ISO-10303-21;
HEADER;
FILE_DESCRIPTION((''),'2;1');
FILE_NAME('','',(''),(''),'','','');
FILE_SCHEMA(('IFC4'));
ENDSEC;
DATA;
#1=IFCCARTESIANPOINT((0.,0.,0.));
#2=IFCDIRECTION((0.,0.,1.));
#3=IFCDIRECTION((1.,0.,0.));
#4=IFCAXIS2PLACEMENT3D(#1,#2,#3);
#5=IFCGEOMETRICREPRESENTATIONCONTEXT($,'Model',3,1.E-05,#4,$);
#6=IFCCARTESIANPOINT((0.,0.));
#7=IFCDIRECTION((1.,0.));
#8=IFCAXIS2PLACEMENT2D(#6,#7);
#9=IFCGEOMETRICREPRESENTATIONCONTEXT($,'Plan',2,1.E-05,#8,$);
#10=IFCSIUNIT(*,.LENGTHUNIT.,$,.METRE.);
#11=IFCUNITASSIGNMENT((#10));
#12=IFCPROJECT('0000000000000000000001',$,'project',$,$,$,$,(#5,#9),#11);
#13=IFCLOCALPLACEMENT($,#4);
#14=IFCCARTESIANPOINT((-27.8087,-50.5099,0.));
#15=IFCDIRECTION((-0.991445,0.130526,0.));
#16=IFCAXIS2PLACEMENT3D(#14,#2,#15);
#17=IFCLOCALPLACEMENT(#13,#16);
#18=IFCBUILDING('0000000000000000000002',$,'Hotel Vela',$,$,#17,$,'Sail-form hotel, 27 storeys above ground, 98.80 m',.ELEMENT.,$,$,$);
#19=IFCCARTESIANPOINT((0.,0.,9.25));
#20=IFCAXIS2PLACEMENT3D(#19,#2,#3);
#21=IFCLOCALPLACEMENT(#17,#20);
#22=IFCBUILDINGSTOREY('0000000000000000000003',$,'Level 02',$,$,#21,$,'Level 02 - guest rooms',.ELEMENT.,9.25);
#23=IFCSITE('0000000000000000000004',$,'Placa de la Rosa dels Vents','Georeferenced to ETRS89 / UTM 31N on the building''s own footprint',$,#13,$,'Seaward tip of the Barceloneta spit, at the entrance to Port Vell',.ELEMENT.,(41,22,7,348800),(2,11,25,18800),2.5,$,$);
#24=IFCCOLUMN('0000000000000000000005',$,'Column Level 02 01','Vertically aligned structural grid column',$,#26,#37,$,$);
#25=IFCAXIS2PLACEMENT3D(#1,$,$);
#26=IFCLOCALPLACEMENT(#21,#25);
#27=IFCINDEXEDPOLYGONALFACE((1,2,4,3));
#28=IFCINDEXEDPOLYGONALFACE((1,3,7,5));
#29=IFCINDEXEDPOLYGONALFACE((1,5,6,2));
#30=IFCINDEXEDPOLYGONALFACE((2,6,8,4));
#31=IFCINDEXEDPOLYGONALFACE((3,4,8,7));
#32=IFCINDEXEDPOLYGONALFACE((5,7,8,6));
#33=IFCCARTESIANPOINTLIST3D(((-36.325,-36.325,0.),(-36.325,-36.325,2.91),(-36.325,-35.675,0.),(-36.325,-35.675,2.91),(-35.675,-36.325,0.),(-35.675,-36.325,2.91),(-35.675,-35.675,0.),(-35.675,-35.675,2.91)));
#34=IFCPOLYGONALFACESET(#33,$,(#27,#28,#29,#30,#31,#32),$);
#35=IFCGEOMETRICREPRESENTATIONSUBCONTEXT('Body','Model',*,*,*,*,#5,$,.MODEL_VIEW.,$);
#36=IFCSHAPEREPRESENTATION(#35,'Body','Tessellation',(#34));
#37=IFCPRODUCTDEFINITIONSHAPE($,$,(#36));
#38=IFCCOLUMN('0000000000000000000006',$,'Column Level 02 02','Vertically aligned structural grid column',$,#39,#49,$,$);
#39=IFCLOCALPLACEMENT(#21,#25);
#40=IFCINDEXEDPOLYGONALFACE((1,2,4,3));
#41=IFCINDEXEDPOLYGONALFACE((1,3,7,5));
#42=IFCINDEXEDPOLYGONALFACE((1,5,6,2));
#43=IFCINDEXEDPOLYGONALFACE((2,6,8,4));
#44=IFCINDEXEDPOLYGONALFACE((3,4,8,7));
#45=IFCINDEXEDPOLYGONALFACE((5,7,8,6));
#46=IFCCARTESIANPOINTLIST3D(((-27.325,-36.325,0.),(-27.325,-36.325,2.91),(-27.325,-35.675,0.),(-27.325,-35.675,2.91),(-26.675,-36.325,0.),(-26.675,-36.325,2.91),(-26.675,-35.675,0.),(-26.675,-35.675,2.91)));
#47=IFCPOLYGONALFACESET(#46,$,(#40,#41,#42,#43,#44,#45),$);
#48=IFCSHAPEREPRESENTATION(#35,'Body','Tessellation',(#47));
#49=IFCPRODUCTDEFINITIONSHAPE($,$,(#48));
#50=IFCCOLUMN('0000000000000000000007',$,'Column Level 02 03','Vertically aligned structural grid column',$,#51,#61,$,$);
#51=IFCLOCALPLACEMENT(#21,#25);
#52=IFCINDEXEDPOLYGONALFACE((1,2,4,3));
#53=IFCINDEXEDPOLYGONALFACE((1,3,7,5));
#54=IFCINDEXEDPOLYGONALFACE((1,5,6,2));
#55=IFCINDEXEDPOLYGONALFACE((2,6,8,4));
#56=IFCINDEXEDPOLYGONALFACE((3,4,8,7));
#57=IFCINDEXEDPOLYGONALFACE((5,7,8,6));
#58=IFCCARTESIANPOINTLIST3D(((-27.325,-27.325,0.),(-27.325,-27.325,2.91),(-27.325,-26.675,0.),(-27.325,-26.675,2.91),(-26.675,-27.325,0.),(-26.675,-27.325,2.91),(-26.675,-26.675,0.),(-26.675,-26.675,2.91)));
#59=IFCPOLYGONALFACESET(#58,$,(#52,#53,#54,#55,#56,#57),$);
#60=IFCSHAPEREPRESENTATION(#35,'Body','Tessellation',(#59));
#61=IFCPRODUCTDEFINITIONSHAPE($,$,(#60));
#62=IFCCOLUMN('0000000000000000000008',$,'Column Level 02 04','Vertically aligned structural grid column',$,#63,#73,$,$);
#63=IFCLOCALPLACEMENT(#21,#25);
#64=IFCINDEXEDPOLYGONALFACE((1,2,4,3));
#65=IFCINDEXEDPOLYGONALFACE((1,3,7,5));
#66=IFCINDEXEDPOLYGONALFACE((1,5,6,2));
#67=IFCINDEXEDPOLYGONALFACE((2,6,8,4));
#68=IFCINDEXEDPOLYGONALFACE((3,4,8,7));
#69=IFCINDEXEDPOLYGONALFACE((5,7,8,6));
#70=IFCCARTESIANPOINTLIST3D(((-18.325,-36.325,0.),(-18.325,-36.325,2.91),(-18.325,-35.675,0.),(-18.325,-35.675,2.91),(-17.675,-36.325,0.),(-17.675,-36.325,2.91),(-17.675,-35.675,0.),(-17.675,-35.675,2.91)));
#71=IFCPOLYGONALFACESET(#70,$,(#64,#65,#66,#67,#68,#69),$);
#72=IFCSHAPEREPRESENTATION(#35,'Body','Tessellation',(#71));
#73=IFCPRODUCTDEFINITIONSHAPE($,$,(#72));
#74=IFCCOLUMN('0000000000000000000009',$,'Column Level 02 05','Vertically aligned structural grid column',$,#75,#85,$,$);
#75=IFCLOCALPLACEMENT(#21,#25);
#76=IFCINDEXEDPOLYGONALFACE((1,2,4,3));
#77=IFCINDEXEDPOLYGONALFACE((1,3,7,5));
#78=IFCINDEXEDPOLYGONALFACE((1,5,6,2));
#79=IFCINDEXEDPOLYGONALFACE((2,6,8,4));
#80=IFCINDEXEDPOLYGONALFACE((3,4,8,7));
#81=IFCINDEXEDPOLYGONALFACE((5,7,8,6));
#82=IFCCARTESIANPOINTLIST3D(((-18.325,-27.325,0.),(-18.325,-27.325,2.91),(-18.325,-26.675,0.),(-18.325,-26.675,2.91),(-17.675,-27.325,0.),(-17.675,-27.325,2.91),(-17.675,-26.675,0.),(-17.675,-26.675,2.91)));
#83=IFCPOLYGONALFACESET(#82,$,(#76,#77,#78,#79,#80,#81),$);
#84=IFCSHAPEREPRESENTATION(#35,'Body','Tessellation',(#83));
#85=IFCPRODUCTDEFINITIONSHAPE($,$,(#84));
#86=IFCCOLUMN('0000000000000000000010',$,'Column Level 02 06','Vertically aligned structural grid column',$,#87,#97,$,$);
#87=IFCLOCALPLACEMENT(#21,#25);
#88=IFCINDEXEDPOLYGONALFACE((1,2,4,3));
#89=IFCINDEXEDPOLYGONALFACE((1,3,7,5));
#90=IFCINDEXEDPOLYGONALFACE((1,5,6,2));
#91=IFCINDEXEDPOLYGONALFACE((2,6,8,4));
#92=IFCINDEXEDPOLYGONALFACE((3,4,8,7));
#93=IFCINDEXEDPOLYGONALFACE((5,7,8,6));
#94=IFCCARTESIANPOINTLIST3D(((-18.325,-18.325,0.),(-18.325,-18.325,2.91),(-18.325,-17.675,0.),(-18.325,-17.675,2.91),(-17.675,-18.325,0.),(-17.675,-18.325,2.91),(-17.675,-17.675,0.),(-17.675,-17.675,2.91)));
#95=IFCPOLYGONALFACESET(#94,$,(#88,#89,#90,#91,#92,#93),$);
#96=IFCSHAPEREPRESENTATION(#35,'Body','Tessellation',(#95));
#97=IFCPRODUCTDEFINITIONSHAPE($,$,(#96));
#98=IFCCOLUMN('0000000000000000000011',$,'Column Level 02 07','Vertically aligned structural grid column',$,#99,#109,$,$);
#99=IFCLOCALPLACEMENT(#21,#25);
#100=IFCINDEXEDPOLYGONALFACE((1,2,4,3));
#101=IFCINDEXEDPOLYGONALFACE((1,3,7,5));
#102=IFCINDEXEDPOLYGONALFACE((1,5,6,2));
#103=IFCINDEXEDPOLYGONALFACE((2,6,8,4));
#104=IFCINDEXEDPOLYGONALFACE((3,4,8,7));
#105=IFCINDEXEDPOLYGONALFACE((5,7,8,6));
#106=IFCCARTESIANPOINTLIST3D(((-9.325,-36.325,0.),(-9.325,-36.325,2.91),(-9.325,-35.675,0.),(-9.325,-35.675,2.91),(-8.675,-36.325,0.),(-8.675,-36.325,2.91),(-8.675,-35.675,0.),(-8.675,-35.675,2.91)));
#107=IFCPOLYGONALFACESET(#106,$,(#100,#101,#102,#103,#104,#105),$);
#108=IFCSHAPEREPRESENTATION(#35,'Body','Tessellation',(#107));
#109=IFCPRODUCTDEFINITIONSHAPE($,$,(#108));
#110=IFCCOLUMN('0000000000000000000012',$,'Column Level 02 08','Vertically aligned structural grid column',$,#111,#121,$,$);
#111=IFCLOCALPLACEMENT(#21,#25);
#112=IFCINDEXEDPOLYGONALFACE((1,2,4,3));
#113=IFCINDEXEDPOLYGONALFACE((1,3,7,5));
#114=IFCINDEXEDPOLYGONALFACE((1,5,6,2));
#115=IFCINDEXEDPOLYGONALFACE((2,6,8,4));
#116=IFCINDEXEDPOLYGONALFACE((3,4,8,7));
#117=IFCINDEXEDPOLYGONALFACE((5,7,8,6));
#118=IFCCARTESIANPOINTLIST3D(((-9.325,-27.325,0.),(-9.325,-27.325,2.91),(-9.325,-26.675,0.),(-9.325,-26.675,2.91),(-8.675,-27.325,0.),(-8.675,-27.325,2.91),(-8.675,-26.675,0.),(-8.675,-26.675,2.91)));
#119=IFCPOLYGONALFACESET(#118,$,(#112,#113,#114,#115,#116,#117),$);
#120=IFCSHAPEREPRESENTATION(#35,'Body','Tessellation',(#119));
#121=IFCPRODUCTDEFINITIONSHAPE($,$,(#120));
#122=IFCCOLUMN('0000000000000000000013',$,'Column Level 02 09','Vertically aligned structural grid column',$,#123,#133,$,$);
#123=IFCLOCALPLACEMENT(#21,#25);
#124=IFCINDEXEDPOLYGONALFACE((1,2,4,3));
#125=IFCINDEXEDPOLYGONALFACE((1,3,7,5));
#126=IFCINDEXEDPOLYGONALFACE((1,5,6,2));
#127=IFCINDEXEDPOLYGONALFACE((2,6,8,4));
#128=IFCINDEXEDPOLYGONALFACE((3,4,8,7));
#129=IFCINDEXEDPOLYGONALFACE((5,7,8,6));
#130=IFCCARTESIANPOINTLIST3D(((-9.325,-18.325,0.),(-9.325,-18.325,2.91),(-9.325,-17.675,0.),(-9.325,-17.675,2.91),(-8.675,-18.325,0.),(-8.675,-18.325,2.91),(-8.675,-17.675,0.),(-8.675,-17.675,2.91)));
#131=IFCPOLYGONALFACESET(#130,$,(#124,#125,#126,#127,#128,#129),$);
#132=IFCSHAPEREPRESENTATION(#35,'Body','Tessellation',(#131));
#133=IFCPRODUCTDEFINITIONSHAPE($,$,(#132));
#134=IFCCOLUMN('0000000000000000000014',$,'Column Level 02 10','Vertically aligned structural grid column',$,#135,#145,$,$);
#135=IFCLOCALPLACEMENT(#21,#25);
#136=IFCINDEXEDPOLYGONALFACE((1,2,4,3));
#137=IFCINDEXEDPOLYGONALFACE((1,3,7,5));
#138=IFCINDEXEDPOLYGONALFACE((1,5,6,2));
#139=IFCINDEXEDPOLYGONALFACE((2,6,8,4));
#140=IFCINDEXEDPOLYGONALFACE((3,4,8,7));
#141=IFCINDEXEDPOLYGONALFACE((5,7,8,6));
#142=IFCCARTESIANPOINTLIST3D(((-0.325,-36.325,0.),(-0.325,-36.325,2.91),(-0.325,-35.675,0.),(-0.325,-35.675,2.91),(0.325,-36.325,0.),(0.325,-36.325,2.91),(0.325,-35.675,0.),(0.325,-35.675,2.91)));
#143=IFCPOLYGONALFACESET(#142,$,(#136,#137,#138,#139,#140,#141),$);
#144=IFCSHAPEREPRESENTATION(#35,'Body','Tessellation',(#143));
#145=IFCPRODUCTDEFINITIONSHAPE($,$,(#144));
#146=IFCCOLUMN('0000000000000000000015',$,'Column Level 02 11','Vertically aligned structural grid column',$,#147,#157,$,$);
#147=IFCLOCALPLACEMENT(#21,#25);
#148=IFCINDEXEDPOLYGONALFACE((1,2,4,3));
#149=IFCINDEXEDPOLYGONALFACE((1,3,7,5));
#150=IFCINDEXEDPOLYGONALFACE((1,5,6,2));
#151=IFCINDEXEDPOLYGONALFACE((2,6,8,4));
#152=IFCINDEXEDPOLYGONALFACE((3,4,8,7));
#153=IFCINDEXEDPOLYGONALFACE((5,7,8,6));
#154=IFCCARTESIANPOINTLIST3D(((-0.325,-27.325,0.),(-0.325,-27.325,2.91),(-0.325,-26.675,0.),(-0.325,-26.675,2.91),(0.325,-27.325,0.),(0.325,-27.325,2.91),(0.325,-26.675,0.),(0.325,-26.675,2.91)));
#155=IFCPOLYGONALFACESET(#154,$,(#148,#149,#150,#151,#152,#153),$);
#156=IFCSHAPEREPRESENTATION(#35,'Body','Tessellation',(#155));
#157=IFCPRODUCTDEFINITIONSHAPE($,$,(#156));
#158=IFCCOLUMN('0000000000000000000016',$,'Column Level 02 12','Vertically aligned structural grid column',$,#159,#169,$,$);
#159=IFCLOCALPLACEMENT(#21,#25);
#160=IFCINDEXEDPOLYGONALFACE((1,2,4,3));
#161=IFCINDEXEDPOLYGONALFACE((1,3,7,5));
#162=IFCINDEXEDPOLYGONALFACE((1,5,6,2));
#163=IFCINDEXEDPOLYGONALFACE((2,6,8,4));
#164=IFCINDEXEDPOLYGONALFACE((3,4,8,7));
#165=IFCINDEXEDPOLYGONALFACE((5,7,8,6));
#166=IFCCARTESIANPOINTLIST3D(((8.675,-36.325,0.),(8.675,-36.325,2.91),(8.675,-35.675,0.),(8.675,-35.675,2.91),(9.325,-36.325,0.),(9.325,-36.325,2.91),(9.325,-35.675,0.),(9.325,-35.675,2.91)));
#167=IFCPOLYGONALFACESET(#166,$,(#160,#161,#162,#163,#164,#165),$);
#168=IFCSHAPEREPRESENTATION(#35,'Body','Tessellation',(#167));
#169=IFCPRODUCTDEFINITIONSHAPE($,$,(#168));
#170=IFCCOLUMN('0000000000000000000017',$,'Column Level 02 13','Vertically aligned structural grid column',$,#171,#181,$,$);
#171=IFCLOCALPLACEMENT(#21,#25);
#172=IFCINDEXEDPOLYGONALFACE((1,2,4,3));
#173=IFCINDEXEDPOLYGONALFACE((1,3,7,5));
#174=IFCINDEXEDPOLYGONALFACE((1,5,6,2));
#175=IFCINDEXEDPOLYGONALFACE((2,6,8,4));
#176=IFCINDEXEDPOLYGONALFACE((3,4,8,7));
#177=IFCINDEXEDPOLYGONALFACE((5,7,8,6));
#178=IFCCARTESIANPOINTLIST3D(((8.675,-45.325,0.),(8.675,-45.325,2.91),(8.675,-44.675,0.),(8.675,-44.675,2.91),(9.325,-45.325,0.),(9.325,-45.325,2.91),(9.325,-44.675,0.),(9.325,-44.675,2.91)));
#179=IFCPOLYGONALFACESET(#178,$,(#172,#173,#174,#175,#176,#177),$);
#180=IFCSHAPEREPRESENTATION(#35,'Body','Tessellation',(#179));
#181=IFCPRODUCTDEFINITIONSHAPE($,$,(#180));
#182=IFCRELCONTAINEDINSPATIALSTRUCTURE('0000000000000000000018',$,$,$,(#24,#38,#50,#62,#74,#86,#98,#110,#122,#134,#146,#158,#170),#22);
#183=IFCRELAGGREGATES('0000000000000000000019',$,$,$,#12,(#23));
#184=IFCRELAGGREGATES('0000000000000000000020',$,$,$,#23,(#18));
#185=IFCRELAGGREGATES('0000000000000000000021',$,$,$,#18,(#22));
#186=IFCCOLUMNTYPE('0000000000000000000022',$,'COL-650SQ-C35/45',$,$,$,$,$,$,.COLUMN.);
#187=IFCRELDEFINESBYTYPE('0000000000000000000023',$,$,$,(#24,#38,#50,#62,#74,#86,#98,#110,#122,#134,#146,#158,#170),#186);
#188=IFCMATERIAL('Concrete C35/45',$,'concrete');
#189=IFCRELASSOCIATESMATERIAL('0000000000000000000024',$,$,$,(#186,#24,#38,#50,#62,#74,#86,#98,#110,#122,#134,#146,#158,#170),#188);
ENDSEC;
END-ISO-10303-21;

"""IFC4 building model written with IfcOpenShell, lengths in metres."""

from ifc_helpers import new_model, si_unit, frame, origin_with_axes, origin_2d_with_axis, place, context, subcontext, project, spatial, line, indexed_curve, rectangle, outline, extrude, material, material_profile, profile_set, profile_usage, type_object, element, save


model = new_model("IFC4")

# Units and contexts
model_context = context("Model", 3, precision=1e-05, world=origin_with_axes())
plan_context = context("Plan", 2, precision=1e-05, world=origin_2d_with_axis())
body_context = subcontext(model_context, "Body", "Model", "MODEL_VIEW")
ifc_project = project(units=[si_unit("LENGTHUNIT", "METRE")], contexts=[model_context, plan_context])

# Site, building, storey
site_placement = place(None, origin_with_axes())
site = spatial("IfcSite", under=ifc_project, at=site_placement, Name="Placa de la Rosa dels Vents", Description="Georeferenced to ETRS89 / UTM 31N on the building's own footprint", LongName="Seaward tip of the Barceloneta spit, at the entrance to Port Vell", CompositionType="ELEMENT", RefLatitude=(41, 22, 7, 348800), RefLongitude=(2, 11, 25, 18800), RefElevation=2.5)
building_placement = place(site_placement, frame((-27.8087, -50.5099, 0.0), z_axis=(0.0, 0.0, 1.0), x_axis=(-0.991445, 0.130526, 0.0)))
building = spatial("IfcBuilding", under=site, at=building_placement, Name="Hotel Vela", LongName="Sail-form hotel, 27 storeys above ground, 98.80 m", CompositionType="ELEMENT")
storey_placement = place(building_placement, frame((0.0, 0.0, 9.25), z_axis=(0.0, 0.0, 1.0), x_axis=(1.0, 0.0, 0.0)))
storey = spatial("IfcBuildingStorey", under=building, at=storey_placement, Name="Level 02", LongName="Level 02 - guest rooms", CompositionType="ELEMENT", Elevation=9.25)

# Columns
ifc_material = material(Name="Concrete C35/45", Category="concrete")
ifc_material_profile = material_profile(ifc_material, rectangle(XDim=0.65, YDim=0.65))
ifc_profile_set = profile_set([ifc_material_profile], Name="COL-650SQ-C35/45")
ifc_profile_usage_1 = profile_usage(ifc_profile_set)
column_type = type_object("IfcColumnType", Name="COL-650SQ-C35/45", PredefinedType="COLUMN", material=ifc_profile_set)
column_1_placement = place(storey_placement, frame((-36.325, -36.325, 0.0), z_axis=(0.0, 0.0, 1.0), x_axis=(1.0, 0.0, 0.0)))
element("IfcColumn", 1, at=column_1_placement, inside=storey, type_object=column_type, material=ifc_profile_usage_1, Name="Column Level 02 01", Description="Vertically aligned structural grid column", context=body_context, shape_type="SweptSolid", body=[
    extrude(outline(indexed_curve([(0.0, 0.0), (0.65, 0.0), (0.65, 0.65), (0.0, 0.65)], segments=[line(1, 2, 3, 4, 1)])), origin_with_axes(), (0.0, 0.0, 1.0), 2.91),
])
ifc_profile_usage_2 = profile_usage(ifc_profile_set)
column_2_placement = place(storey_placement, frame((-27.325, -36.325, 0.0), z_axis=(0.0, 0.0, 1.0), x_axis=(1.0, 0.0, 0.0)))
element("IfcColumn", 2, at=column_2_placement, inside=storey, type_object=column_type, material=ifc_profile_usage_2, Name="Column Level 02 02", Description="Vertically aligned structural grid column", context=body_context, shape_type="SweptSolid", body=[
    extrude(outline(indexed_curve([(0.0, 0.0), (0.65, 0.0), (0.65, 0.65), (0.0, 0.65)], segments=[line(1, 2, 3, 4, 1)])), origin_with_axes(), (0.0, 0.0, 1.0), 2.91),
])
ifc_profile_usage_3 = profile_usage(ifc_profile_set)
column_3_placement = place(storey_placement, frame((-27.325, -27.325, 0.0), z_axis=(0.0, 0.0, 1.0), x_axis=(1.0, 0.0, 0.0)))
element("IfcColumn", 3, at=column_3_placement, inside=storey, type_object=column_type, material=ifc_profile_usage_3, Name="Column Level 02 03", Description="Vertically aligned structural grid column", context=body_context, shape_type="SweptSolid", body=[
    extrude(outline(indexed_curve([(0.0, 0.0), (0.65, 0.0), (0.65, 0.65), (0.0, 0.65)], segments=[line(1, 2, 3, 4, 1)])), origin_with_axes(), (0.0, 0.0, 1.0), 2.91),
])
ifc_profile_usage_4 = profile_usage(ifc_profile_set)
column_4_placement = place(storey_placement, frame((-18.325, -36.325, 0.0), z_axis=(0.0, 0.0, 1.0), x_axis=(1.0, 0.0, 0.0)))
element("IfcColumn", 4, at=column_4_placement, inside=storey, type_object=column_type, material=ifc_profile_usage_4, Name="Column Level 02 04", Description="Vertically aligned structural grid column", context=body_context, shape_type="SweptSolid", body=[
    extrude(outline(indexed_curve([(0.0, 0.0), (0.65, 0.0), (0.65, 0.65), (0.0, 0.65)], segments=[line(1, 2, 3, 4, 1)])), origin_with_axes(), (0.0, 0.0, 1.0), 2.91),
])
ifc_profile_usage_5 = profile_usage(ifc_profile_set)
column_5_placement = place(storey_placement, frame((-18.325, -27.325, 0.0), z_axis=(0.0, 0.0, 1.0), x_axis=(1.0, 0.0, 0.0)))
element("IfcColumn", 5, at=column_5_placement, inside=storey, type_object=column_type, material=ifc_profile_usage_5, Name="Column Level 02 05", Description="Vertically aligned structural grid column", context=body_context, shape_type="SweptSolid", body=[
    extrude(outline(indexed_curve([(0.0, 0.0), (0.65, 0.0), (0.65, 0.65), (0.0, 0.65)], segments=[line(1, 2, 3, 4, 1)])), origin_with_axes(), (0.0, 0.0, 1.0), 2.91),
])
ifc_profile_usage_6 = profile_usage(ifc_profile_set)
column_6_placement = place(storey_placement, frame((-18.325, -18.325, 0.0), z_axis=(0.0, 0.0, 1.0), x_axis=(1.0, 0.0, 0.0)))
element("IfcColumn", 6, at=column_6_placement, inside=storey, type_object=column_type, material=ifc_profile_usage_6, Name="Column Level 02 06", Description="Vertically aligned structural grid column", context=body_context, shape_type="SweptSolid", body=[
    extrude(outline(indexed_curve([(0.0, 0.0), (0.65, 0.0), (0.65, 0.65), (0.0, 0.65)], segments=[line(1, 2, 3, 4, 1)])), origin_with_axes(), (0.0, 0.0, 1.0), 2.91),
])
ifc_profile_usage_7 = profile_usage(ifc_profile_set)
column_7_placement = place(storey_placement, frame((-9.325, -36.325, 0.0), z_axis=(0.0, 0.0, 1.0), x_axis=(1.0, 0.0, 0.0)))
element("IfcColumn", 7, at=column_7_placement, inside=storey, type_object=column_type, material=ifc_profile_usage_7, Name="Column Level 02 07", Description="Vertically aligned structural grid column", context=body_context, shape_type="SweptSolid", body=[
    extrude(outline(indexed_curve([(0.0, 0.0), (0.65, 0.0), (0.65, 0.65), (0.0, 0.65)], segments=[line(1, 2, 3, 4, 1)])), origin_with_axes(), (0.0, 0.0, 1.0), 2.91),
])
ifc_profile_usage_8 = profile_usage(ifc_profile_set)
column_8_placement = place(storey_placement, frame((-9.325, -27.325, 0.0), z_axis=(0.0, 0.0, 1.0), x_axis=(1.0, 0.0, 0.0)))
element("IfcColumn", 8, at=column_8_placement, inside=storey, type_object=column_type, material=ifc_profile_usage_8, Name="Column Level 02 08", Description="Vertically aligned structural grid column", context=body_context, shape_type="SweptSolid", body=[
    extrude(outline(indexed_curve([(0.0, 0.0), (0.65, 0.0), (0.65, 0.65), (0.0, 0.65)], segments=[line(1, 2, 3, 4, 1)])), origin_with_axes(), (0.0, 0.0, 1.0), 2.91),
])
ifc_profile_usage_9 = profile_usage(ifc_profile_set)
column_9_placement = place(storey_placement, frame((-9.325, -18.325, 0.0), z_axis=(0.0, 0.0, 1.0), x_axis=(1.0, 0.0, 0.0)))
element("IfcColumn", 9, at=column_9_placement, inside=storey, type_object=column_type, material=ifc_profile_usage_9, Name="Column Level 02 09", Description="Vertically aligned structural grid column", context=body_context, shape_type="SweptSolid", body=[
    extrude(outline(indexed_curve([(0.0, 0.0), (0.65, 0.0), (0.65, 0.65), (0.0, 0.65)], segments=[line(1, 2, 3, 4, 1)])), origin_with_axes(), (0.0, 0.0, 1.0), 2.91),
])
ifc_profile_usage_10 = profile_usage(ifc_profile_set)
column_10_placement = place(storey_placement, frame((-0.325, -36.325, 0.0), z_axis=(0.0, 0.0, 1.0), x_axis=(1.0, 0.0, 0.0)))
element("IfcColumn", 10, at=column_10_placement, inside=storey, type_object=column_type, material=ifc_profile_usage_10, Name="Column Level 02 10", Description="Vertically aligned structural grid column", context=body_context, shape_type="SweptSolid", body=[
    extrude(outline(indexed_curve([(0.0, 0.0), (0.65, 0.0), (0.65, 0.65), (0.0, 0.65)], segments=[line(1, 2, 3, 4, 1)])), origin_with_axes(), (0.0, 0.0, 1.0), 2.91),
])
ifc_profile_usage_11 = profile_usage(ifc_profile_set)
column_11_placement = place(storey_placement, frame((-0.325, -27.325, 0.0), z_axis=(0.0, 0.0, 1.0), x_axis=(1.0, 0.0, 0.0)))
element("IfcColumn", 11, at=column_11_placement, inside=storey, type_object=column_type, material=ifc_profile_usage_11, Name="Column Level 02 11", Description="Vertically aligned structural grid column", context=body_context, shape_type="SweptSolid", body=[
    extrude(outline(indexed_curve([(0.0, 0.0), (0.65, 0.0), (0.65, 0.65), (0.0, 0.65)], segments=[line(1, 2, 3, 4, 1)])), origin_with_axes(), (0.0, 0.0, 1.0), 2.91),
])
ifc_profile_usage_12 = profile_usage(ifc_profile_set)
column_12_placement = place(storey_placement, frame((8.675, -36.325, 0.0), z_axis=(0.0, 0.0, 1.0), x_axis=(1.0, 0.0, 0.0)))
element("IfcColumn", 12, at=column_12_placement, inside=storey, type_object=column_type, material=ifc_profile_usage_12, Name="Column Level 02 12", Description="Vertically aligned structural grid column", context=body_context, shape_type="SweptSolid", body=[
    extrude(outline(indexed_curve([(0.0, 0.0), (0.65, 0.0), (0.65, 0.65), (0.0, 0.65)], segments=[line(1, 2, 3, 4, 1)])), origin_with_axes(), (0.0, 0.0, 1.0), 2.91),
])
ifc_profile_usage_13 = profile_usage(ifc_profile_set)
column_13_placement = place(storey_placement, frame((8.675, -45.325, 0.0), z_axis=(0.0, 0.0, 1.0), x_axis=(1.0, 0.0, 0.0)))
element("IfcColumn", 13, at=column_13_placement, inside=storey, type_object=column_type, material=ifc_profile_usage_13, Name="Column Level 02 13", Description="Vertically aligned structural grid column", context=body_context, shape_type="SweptSolid", body=[
    extrude(outline(indexed_curve([(0.0, 0.0), (0.65, 0.0), (0.65, 0.65), (0.0, 0.65)], segments=[line(1, 2, 3, 4, 1)])), origin_with_axes(), (0.0, 0.0, 1.0), 2.91),
])

save(model, "model.ifc")
